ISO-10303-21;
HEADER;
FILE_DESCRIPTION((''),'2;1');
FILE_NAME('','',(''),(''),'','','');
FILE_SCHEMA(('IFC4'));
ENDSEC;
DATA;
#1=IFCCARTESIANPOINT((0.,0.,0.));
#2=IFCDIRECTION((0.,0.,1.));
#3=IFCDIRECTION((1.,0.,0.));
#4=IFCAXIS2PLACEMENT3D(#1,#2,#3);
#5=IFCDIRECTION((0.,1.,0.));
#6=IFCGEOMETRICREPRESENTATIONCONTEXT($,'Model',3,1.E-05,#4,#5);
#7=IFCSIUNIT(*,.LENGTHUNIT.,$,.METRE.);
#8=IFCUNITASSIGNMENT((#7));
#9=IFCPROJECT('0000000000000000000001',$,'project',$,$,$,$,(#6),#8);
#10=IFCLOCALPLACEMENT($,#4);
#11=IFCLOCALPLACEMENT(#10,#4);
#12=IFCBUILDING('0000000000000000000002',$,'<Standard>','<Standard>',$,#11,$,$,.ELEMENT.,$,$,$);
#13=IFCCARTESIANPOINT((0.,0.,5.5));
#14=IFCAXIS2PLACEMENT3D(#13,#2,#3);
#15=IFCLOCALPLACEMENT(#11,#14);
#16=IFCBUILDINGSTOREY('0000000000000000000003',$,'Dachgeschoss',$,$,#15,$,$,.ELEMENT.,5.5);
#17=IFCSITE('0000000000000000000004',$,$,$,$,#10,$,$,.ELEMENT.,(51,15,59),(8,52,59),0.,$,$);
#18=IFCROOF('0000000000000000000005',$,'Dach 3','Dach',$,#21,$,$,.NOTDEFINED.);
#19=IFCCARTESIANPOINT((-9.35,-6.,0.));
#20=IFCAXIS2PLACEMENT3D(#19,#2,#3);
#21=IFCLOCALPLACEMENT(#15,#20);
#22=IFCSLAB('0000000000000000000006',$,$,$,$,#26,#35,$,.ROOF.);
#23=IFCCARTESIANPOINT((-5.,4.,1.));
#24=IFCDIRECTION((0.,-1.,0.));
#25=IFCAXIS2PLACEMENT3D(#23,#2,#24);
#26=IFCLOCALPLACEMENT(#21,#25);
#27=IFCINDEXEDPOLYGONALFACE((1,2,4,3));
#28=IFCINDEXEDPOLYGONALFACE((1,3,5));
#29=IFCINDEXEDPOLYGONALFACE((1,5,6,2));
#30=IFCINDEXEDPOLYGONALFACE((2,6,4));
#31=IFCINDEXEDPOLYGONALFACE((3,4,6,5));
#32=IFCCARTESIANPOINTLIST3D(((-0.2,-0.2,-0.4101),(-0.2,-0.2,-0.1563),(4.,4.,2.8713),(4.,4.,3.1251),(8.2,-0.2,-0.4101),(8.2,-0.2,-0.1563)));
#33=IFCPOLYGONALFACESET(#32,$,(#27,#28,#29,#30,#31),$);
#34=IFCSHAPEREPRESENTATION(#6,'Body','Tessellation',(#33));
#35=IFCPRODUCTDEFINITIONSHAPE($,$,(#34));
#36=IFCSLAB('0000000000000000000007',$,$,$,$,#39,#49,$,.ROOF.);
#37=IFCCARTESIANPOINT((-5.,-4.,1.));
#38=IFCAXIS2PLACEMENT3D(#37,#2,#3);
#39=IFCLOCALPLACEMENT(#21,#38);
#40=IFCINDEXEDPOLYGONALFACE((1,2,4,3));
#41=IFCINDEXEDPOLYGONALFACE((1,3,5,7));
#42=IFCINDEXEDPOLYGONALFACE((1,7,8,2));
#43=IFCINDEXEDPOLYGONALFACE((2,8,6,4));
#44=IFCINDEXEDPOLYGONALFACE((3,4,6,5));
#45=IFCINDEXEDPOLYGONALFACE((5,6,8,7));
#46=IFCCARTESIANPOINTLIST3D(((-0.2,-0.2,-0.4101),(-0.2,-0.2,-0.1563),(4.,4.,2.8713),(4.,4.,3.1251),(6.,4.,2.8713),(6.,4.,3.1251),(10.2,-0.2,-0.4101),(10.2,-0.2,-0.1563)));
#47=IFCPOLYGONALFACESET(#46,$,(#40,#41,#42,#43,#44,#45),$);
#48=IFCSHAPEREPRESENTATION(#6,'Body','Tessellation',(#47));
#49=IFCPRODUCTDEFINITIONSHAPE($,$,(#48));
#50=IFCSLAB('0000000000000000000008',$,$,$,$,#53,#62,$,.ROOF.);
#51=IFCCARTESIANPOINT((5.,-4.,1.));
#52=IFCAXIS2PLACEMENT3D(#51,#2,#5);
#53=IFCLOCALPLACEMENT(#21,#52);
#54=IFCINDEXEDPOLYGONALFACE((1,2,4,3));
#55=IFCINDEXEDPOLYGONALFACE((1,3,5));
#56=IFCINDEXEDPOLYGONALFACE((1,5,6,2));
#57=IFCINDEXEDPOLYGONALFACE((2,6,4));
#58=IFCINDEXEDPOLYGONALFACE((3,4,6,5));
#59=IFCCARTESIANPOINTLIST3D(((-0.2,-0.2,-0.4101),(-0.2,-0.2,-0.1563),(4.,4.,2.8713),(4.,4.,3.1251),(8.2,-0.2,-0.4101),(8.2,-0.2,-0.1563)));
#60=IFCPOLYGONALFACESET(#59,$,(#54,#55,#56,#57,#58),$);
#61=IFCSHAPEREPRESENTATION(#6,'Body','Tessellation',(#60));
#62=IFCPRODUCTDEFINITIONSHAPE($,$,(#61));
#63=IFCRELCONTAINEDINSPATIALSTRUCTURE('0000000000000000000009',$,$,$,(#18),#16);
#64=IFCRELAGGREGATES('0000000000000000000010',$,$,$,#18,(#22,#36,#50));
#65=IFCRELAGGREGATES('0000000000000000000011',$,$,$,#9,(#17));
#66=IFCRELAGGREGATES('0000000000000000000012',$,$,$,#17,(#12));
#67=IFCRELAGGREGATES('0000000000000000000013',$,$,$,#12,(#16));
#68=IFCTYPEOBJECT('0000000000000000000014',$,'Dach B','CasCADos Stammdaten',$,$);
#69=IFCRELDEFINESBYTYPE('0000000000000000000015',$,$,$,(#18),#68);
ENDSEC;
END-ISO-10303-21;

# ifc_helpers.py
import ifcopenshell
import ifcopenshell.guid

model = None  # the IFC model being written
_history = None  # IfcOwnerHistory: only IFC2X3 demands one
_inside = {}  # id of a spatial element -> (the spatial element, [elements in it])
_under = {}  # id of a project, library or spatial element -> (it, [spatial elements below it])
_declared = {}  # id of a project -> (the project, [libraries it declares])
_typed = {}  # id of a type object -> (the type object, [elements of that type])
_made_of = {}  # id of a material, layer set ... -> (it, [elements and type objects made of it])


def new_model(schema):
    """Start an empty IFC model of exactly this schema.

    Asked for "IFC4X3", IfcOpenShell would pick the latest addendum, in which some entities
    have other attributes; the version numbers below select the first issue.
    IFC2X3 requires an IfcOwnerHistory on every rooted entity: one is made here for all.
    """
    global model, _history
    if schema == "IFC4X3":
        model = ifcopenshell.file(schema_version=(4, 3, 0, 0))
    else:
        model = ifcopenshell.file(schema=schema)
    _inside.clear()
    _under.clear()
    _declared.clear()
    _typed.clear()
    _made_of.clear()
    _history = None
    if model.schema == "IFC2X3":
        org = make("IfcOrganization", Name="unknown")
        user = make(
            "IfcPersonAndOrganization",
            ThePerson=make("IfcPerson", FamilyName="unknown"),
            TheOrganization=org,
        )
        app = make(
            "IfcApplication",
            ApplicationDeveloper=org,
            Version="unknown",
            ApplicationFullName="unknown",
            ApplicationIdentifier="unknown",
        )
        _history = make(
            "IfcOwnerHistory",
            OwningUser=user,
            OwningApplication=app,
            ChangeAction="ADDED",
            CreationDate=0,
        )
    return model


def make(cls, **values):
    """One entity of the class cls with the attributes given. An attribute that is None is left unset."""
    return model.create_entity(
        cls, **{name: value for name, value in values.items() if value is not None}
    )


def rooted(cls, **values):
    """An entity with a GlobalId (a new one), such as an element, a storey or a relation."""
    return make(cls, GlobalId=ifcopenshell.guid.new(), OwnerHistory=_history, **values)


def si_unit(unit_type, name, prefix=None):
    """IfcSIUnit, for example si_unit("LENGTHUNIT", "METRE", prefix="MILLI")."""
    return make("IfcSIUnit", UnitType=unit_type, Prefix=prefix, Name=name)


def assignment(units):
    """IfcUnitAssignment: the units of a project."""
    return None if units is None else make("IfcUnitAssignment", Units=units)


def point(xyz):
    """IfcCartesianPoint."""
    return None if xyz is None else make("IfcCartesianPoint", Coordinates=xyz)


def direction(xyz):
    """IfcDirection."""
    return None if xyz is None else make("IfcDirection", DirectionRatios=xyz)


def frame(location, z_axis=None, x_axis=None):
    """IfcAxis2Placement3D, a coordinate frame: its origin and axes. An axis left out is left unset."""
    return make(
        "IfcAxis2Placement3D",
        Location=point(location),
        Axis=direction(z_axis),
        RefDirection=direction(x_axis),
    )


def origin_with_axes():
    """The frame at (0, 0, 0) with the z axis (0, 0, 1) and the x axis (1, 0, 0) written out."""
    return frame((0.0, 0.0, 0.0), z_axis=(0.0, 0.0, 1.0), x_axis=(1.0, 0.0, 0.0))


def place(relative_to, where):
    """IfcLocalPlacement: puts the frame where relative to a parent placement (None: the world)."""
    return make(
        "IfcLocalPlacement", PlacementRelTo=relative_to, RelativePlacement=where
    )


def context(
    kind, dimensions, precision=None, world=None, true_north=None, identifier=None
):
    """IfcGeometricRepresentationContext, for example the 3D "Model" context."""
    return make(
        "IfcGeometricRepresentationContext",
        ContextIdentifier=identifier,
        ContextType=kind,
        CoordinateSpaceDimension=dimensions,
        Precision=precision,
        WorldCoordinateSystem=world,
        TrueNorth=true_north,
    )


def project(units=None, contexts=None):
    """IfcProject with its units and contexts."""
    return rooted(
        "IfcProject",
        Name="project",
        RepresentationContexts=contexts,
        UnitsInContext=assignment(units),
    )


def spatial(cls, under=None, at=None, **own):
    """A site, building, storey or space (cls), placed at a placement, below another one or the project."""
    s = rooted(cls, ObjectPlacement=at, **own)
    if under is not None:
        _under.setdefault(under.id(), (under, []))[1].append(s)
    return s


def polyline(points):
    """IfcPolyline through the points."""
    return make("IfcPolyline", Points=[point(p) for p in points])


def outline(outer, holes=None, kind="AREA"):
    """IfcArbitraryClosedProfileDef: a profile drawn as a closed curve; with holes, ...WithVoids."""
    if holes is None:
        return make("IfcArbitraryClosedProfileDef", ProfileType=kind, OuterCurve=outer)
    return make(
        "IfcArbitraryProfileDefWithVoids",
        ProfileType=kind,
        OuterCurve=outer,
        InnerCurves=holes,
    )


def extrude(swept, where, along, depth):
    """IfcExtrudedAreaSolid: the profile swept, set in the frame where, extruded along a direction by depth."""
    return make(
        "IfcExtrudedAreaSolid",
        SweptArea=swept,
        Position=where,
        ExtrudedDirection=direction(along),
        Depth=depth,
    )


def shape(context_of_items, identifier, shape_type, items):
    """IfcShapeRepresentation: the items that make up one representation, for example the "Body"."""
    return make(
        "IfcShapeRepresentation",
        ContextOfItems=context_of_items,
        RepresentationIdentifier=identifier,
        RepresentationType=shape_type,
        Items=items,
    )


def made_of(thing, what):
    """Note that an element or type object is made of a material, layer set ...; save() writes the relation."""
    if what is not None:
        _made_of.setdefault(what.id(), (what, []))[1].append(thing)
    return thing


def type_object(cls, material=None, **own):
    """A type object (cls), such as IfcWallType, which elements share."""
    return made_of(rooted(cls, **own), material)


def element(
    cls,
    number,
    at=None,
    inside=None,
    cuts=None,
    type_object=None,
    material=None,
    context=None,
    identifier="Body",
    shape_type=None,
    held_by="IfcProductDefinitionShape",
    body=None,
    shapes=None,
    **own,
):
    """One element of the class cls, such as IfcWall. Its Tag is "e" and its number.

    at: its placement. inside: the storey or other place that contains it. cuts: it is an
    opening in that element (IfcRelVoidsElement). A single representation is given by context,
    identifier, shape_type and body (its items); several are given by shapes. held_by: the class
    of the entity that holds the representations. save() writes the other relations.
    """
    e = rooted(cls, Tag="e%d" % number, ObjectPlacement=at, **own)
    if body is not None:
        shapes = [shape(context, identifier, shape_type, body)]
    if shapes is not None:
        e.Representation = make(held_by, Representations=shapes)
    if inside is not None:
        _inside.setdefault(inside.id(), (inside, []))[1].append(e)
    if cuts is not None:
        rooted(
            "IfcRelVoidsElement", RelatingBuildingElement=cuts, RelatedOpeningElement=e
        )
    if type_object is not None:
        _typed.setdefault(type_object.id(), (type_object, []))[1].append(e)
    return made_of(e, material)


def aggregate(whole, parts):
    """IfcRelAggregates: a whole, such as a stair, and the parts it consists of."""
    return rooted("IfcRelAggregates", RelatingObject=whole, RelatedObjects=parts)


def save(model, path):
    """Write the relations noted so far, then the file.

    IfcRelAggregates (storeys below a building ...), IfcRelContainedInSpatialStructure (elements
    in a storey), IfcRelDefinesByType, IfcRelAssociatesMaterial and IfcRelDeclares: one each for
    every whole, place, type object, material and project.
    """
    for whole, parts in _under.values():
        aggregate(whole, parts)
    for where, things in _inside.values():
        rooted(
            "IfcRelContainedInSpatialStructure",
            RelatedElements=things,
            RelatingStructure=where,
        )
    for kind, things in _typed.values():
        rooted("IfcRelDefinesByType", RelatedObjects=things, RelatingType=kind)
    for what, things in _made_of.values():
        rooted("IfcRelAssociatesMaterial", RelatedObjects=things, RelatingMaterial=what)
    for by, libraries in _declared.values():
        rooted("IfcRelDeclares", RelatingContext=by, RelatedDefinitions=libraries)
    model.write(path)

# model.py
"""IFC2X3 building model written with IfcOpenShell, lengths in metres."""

from ifc_helpers import new_model, si_unit, direction, frame, origin_with_axes, place, context, project, spatial, polyline, outline, extrude, type_object, element, aggregate, save


model = new_model("IFC2X3")

# Units and contexts
model_context = context("Model", 3, precision=1e-05, world=origin_with_axes(), true_north=direction((0.0, 1.0, 0.0)))
ifc_project = project(units=[si_unit("LENGTHUNIT", "METRE")], contexts=[model_context])

# Site, building, storey
site_placement = place(None, origin_with_axes())
site = spatial("IfcSite", under=ifc_project, at=site_placement, CompositionType="ELEMENT", RefLatitude=(51, 15, 59), RefLongitude=(8, 52, 59), RefElevation=0.0)
building_placement = place(site_placement, origin_with_axes())
building = spatial("IfcBuilding", under=site, at=building_placement, Name="<Standard>", Description="<Standard>", CompositionType="ELEMENT")
storey_placement = place(building_placement, frame((0.0, 0.0, 5.5), z_axis=(0.0, 0.0, 1.0), x_axis=(1.0, 0.0, 0.0)))
storey = spatial("IfcBuildingStorey", under=building, at=storey_placement, Name="Dachgeschoss", CompositionType="ELEMENT", Elevation=5.5)

# Roof, slabs
ifc_type_object_1 = type_object("IfcTypeObject", Name="Dach B", Description="CasCADos Stammdaten")
roof_1_placement = place(storey_placement, frame((-9.35, -6.0, 0.0), z_axis=(0.0, 0.0, 1.0), x_axis=(1.0, 0.0, 0.0)))
roof_1 = element("IfcRoof", 1, at=roof_1_placement, inside=storey, type_object=ifc_type_object_1, Name="Dach 3", Description="Dach", ShapeType="NOTDEFINED")
slab_1_placement = place(roof_1_placement, frame((-5.0, 4.0, 1.0), z_axis=(0.0, 0.0, 1.0), x_axis=(0.0, -1.0, 0.0)))
slab_1 = element("IfcSlab", 2, at=slab_1_placement, PredefinedType="ROOF", context=model_context, shape_type="SweptSolid", body=[
    extrude(outline(polyline([(8.2, 0.2538), (-0.2, 0.2538), (4.0, -5.0761), (8.2, 0.2538)])), frame((0.0, 0.0, 0.0), z_axis=(0.0, 0.615661, -0.788011), x_axis=(1.0, 0.0, 0.0)), (0.0, 0.615661, 0.788011), 0.2538),
])
slab_2_placement = place(roof_1_placement, frame((-5.0, -4.0, 1.0), z_axis=(0.0, 0.0, 1.0), x_axis=(1.0, 0.0, 0.0)))
slab_2 = element("IfcSlab", 3, at=slab_2_placement, PredefinedType="ROOF", context=model_context, shape_type="SweptSolid", body=[
    extrude(outline(polyline([(10.2, 0.2538), (-0.2, 0.2538), (4.0, -5.0761), (6.0, -5.0761), (10.2, 0.2538)])), frame((0.0, 0.0, 0.0), z_axis=(0.0, 0.615661, -0.788011), x_axis=(1.0, 0.0, 0.0)), (0.0, 0.615661, 0.788011), 0.2538),
])
slab_3_placement = place(roof_1_placement, frame((5.0, -4.0, 1.0), z_axis=(0.0, 0.0, 1.0), x_axis=(0.0, 1.0, 0.0)))
slab_3 = element("IfcSlab", 4, at=slab_3_placement, PredefinedType="ROOF", context=model_context, shape_type="SweptSolid", body=[
    extrude(outline(polyline([(8.2, 0.2538), (-0.2, 0.2538), (4.0, -5.0761), (8.2, 0.2538)])), frame((0.0, 0.0, 0.0), z_axis=(0.0, 0.615661, -0.788011), x_axis=(1.0, 0.0, 0.0)), (0.0, 0.615661, 0.788011), 0.2538),
])
aggregate(roof_1, [slab_1, slab_2, slab_3])

save(model, "model.ifc")
